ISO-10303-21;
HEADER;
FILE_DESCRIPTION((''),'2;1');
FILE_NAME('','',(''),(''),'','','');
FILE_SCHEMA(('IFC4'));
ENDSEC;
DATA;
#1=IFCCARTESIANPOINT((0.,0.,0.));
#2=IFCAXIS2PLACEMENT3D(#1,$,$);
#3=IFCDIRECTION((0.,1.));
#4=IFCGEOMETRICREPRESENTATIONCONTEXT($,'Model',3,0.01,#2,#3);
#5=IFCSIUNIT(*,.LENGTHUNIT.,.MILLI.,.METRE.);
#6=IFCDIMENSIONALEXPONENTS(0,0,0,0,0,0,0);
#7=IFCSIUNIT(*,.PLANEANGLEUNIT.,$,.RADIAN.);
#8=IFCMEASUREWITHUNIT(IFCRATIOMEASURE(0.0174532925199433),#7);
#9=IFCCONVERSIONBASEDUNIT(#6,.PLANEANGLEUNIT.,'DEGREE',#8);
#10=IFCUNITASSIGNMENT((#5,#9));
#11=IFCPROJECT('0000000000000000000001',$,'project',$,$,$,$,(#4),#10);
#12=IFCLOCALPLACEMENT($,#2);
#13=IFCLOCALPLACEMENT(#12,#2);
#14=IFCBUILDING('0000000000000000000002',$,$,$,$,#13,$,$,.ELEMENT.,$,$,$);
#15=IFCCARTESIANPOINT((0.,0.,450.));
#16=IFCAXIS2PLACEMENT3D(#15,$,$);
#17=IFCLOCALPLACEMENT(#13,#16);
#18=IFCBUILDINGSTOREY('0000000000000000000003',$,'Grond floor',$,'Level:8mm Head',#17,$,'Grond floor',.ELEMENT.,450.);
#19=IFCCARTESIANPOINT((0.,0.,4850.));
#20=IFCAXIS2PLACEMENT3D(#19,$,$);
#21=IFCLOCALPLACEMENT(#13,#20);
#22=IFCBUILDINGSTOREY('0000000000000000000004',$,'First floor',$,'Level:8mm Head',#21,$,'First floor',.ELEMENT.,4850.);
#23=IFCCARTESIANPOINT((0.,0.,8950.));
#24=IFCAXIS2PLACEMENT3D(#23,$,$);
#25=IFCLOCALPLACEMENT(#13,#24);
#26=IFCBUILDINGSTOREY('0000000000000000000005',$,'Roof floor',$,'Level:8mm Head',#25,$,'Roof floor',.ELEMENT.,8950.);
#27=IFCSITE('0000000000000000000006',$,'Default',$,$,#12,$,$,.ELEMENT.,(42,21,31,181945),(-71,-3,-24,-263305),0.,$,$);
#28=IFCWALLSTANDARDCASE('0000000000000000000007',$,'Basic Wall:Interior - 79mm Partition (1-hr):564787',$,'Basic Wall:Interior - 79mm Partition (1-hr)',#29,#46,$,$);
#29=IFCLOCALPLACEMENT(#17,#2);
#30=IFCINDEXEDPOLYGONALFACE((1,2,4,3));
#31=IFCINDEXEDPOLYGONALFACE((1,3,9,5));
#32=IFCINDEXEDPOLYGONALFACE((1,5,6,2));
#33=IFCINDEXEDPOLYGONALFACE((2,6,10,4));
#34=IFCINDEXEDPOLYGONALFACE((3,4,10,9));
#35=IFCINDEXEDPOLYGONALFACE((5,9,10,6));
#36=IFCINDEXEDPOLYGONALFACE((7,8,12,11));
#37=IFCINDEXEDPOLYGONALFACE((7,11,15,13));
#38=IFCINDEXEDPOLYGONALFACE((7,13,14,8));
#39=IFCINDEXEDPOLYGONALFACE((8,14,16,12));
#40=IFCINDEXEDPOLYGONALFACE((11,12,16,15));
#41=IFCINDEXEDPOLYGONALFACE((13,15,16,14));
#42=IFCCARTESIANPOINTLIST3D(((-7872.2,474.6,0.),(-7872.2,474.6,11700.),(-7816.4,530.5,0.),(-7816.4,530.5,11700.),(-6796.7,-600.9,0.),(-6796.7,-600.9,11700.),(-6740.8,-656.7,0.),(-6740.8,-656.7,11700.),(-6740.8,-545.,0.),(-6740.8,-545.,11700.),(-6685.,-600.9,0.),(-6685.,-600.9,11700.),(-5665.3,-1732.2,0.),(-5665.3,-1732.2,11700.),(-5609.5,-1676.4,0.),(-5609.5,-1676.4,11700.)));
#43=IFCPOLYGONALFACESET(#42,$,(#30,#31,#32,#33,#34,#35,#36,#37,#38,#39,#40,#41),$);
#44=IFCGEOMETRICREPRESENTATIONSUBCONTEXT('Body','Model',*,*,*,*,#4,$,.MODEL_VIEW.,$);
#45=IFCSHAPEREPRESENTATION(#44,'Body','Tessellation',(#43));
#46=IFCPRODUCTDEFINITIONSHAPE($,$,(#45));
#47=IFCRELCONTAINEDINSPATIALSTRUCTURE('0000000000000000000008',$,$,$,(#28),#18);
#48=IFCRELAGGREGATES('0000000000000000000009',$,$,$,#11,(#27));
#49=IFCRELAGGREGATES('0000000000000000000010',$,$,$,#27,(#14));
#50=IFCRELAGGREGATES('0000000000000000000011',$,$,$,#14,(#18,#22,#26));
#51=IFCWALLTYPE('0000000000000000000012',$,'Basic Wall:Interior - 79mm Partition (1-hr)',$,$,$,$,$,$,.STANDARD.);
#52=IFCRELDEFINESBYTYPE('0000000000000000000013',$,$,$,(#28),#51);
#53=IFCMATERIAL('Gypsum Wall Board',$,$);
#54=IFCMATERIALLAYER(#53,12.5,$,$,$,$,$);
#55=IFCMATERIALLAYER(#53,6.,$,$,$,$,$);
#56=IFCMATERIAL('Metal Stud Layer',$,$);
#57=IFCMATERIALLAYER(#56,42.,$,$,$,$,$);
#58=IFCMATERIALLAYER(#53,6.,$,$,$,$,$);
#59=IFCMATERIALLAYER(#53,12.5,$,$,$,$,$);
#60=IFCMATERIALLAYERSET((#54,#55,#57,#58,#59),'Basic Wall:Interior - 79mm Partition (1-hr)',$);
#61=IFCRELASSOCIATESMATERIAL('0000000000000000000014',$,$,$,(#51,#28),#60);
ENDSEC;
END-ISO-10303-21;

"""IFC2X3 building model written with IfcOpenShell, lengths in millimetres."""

from ifc_helpers import new_model, entity, si_unit, converted_unit, direction, frame, frame_2d, origin, place, context, subcontext, project, spatial, rectangle, extrude, material, layer, layer_set, layer_usage, type_object, element, save


model = new_model("IFC2X3")

# Units and contexts
model_context = context("Model", 3, precision=0.01, world=origin(), true_north=direction((0.0, 1.0)))
body_context = subcontext(model_context, "Body", "Model", "MODEL_VIEW")
ifc_project = project(units=[si_unit("LENGTHUNIT", "METRE", prefix="MILLI"), converted_unit("PLANEANGLEUNIT", "DEGREE", entity("IfcRatioMeasure", 0.0174532925199433), si_unit("PLANEANGLEUNIT", "RADIAN"), dimensions=[0, 0, 0, 0, 0, 0, 0])], contexts=[model_context])

# Site, building, storey
site_placement = place(None, origin())
site = spatial("IfcSite", under=ifc_project, at=site_placement, Name="Default", CompositionType="ELEMENT", RefLatitude=(42, 21, 31, 181945), RefLongitude=(-71, -3, -24, -263305), RefElevation=0.0)
building_placement = place(site_placement, origin())
building = spatial("IfcBuilding", under=site, at=building_placement, CompositionType="ELEMENT")
storey_1_placement = place(building_placement, frame((0.0, 0.0, 450.0)))
storey_1 = spatial("IfcBuildingStorey", under=building, at=storey_1_placement, Name="Grond floor", ObjectType="Level:8mm Head", LongName="Grond floor", CompositionType="ELEMENT", Elevation=450.0)

# Shared definitions
ifc_material_1 = material(Name="Gypsum Wall Board")

# Shared definitions
storey_2_placement = place(building_placement, frame((0.0, 0.0, 4850.0)))
storey_2 = spatial("IfcBuildingStorey", under=building, at=storey_2_placement, Name="First floor", ObjectType="Level:8mm Head", LongName="First floor", CompositionType="ELEMENT", Elevation=4850.0)

# Shared definitions
storey_3_placement = place(building_placement, frame((0.0, 0.0, 8950.0)))
storey_3 = spatial("IfcBuildingStorey", under=building, at=storey_3_placement, Name="Roof floor", ObjectType="Level:8mm Head", LongName="Roof floor", CompositionType="ELEMENT", Elevation=8950.0)

# Shared definitions
ifc_layer_1 = layer(ifc_material_1, 12.5)
ifc_layer_2 = layer(ifc_material_1, 6.0)
ifc_material_2 = material(Name="Metal Stud Layer")
ifc_layer_3 = layer(ifc_material_2, 42.0)
ifc_layer_4 = layer(ifc_material_1, 6.0)
ifc_layer_5 = layer(ifc_material_1, 12.5)
ifc_layer_set_1 = layer_set([ifc_layer_1, ifc_layer_2, ifc_layer_3, ifc_layer_4, ifc_layer_5], Name="Basic Wall:Interior - 79mm Partition (1-hr)")
wall_type_1 = type_object("IfcWallType", Name="Basic Wall:Interior - 79mm Partition (1-hr)", PredefinedType="STANDARD", material=ifc_layer_set_1)

# Wall, opening
ifc_layer_usage_1 = layer_usage(ifc_layer_set_1, "AXIS2", "NEGATIVE", 39.5)
wall_1_placement = place(storey_1_placement, frame((-5637.4, -1704.3, 0.0), z_axis=(0.0, 0.0, 1.0), x_axis=(-0.707107, 0.707107, 0.0)))
wall_1 = element("IfcWallStandardCase", 1, at=wall_1_placement, inside=storey_1, type_object=wall_type_1, material=ifc_layer_usage_1, Name="Basic Wall:Interior - 79mm Partition (1-hr):564787", ObjectType="Basic Wall:Interior - 79mm Partition (1-hr)", context=body_context, shape_type="SweptSolid", body=[
    extrude(rectangle(XDim=3121.0, YDim=79.0, at=frame_2d((1560.5, 0.0), x_axis=(-1.0, 0.0))), origin(), (0.0, 0.0, 1.0), 11700.0),
])
opening_1_placement = place(storey_1_placement, frame((-5637.4, -1704.3, 0.0), z_axis=(0.0, 0.0, 1.0), x_axis=(-0.707107, 0.707107, 0.0)))
element("IfcOpeningElement", 2, at=opening_1_placement, cuts=wall_1, ObjectType="Opening", context=body_context, shape_type="SweptSolid", body=[
    extrude(rectangle(XDim=11700.0, YDim=79.0, at=frame_2d((0.0, 0.0), x_axis=(1.0, 0.0))), frame((1521.0, 0.0, 5850.0), z_axis=(1.0, 0.0, 0.0), x_axis=(0.0, 0.0, -1.0)), (0.0, 0.0, 1.0), 79.0),
])

save(model, "model.ifc")
